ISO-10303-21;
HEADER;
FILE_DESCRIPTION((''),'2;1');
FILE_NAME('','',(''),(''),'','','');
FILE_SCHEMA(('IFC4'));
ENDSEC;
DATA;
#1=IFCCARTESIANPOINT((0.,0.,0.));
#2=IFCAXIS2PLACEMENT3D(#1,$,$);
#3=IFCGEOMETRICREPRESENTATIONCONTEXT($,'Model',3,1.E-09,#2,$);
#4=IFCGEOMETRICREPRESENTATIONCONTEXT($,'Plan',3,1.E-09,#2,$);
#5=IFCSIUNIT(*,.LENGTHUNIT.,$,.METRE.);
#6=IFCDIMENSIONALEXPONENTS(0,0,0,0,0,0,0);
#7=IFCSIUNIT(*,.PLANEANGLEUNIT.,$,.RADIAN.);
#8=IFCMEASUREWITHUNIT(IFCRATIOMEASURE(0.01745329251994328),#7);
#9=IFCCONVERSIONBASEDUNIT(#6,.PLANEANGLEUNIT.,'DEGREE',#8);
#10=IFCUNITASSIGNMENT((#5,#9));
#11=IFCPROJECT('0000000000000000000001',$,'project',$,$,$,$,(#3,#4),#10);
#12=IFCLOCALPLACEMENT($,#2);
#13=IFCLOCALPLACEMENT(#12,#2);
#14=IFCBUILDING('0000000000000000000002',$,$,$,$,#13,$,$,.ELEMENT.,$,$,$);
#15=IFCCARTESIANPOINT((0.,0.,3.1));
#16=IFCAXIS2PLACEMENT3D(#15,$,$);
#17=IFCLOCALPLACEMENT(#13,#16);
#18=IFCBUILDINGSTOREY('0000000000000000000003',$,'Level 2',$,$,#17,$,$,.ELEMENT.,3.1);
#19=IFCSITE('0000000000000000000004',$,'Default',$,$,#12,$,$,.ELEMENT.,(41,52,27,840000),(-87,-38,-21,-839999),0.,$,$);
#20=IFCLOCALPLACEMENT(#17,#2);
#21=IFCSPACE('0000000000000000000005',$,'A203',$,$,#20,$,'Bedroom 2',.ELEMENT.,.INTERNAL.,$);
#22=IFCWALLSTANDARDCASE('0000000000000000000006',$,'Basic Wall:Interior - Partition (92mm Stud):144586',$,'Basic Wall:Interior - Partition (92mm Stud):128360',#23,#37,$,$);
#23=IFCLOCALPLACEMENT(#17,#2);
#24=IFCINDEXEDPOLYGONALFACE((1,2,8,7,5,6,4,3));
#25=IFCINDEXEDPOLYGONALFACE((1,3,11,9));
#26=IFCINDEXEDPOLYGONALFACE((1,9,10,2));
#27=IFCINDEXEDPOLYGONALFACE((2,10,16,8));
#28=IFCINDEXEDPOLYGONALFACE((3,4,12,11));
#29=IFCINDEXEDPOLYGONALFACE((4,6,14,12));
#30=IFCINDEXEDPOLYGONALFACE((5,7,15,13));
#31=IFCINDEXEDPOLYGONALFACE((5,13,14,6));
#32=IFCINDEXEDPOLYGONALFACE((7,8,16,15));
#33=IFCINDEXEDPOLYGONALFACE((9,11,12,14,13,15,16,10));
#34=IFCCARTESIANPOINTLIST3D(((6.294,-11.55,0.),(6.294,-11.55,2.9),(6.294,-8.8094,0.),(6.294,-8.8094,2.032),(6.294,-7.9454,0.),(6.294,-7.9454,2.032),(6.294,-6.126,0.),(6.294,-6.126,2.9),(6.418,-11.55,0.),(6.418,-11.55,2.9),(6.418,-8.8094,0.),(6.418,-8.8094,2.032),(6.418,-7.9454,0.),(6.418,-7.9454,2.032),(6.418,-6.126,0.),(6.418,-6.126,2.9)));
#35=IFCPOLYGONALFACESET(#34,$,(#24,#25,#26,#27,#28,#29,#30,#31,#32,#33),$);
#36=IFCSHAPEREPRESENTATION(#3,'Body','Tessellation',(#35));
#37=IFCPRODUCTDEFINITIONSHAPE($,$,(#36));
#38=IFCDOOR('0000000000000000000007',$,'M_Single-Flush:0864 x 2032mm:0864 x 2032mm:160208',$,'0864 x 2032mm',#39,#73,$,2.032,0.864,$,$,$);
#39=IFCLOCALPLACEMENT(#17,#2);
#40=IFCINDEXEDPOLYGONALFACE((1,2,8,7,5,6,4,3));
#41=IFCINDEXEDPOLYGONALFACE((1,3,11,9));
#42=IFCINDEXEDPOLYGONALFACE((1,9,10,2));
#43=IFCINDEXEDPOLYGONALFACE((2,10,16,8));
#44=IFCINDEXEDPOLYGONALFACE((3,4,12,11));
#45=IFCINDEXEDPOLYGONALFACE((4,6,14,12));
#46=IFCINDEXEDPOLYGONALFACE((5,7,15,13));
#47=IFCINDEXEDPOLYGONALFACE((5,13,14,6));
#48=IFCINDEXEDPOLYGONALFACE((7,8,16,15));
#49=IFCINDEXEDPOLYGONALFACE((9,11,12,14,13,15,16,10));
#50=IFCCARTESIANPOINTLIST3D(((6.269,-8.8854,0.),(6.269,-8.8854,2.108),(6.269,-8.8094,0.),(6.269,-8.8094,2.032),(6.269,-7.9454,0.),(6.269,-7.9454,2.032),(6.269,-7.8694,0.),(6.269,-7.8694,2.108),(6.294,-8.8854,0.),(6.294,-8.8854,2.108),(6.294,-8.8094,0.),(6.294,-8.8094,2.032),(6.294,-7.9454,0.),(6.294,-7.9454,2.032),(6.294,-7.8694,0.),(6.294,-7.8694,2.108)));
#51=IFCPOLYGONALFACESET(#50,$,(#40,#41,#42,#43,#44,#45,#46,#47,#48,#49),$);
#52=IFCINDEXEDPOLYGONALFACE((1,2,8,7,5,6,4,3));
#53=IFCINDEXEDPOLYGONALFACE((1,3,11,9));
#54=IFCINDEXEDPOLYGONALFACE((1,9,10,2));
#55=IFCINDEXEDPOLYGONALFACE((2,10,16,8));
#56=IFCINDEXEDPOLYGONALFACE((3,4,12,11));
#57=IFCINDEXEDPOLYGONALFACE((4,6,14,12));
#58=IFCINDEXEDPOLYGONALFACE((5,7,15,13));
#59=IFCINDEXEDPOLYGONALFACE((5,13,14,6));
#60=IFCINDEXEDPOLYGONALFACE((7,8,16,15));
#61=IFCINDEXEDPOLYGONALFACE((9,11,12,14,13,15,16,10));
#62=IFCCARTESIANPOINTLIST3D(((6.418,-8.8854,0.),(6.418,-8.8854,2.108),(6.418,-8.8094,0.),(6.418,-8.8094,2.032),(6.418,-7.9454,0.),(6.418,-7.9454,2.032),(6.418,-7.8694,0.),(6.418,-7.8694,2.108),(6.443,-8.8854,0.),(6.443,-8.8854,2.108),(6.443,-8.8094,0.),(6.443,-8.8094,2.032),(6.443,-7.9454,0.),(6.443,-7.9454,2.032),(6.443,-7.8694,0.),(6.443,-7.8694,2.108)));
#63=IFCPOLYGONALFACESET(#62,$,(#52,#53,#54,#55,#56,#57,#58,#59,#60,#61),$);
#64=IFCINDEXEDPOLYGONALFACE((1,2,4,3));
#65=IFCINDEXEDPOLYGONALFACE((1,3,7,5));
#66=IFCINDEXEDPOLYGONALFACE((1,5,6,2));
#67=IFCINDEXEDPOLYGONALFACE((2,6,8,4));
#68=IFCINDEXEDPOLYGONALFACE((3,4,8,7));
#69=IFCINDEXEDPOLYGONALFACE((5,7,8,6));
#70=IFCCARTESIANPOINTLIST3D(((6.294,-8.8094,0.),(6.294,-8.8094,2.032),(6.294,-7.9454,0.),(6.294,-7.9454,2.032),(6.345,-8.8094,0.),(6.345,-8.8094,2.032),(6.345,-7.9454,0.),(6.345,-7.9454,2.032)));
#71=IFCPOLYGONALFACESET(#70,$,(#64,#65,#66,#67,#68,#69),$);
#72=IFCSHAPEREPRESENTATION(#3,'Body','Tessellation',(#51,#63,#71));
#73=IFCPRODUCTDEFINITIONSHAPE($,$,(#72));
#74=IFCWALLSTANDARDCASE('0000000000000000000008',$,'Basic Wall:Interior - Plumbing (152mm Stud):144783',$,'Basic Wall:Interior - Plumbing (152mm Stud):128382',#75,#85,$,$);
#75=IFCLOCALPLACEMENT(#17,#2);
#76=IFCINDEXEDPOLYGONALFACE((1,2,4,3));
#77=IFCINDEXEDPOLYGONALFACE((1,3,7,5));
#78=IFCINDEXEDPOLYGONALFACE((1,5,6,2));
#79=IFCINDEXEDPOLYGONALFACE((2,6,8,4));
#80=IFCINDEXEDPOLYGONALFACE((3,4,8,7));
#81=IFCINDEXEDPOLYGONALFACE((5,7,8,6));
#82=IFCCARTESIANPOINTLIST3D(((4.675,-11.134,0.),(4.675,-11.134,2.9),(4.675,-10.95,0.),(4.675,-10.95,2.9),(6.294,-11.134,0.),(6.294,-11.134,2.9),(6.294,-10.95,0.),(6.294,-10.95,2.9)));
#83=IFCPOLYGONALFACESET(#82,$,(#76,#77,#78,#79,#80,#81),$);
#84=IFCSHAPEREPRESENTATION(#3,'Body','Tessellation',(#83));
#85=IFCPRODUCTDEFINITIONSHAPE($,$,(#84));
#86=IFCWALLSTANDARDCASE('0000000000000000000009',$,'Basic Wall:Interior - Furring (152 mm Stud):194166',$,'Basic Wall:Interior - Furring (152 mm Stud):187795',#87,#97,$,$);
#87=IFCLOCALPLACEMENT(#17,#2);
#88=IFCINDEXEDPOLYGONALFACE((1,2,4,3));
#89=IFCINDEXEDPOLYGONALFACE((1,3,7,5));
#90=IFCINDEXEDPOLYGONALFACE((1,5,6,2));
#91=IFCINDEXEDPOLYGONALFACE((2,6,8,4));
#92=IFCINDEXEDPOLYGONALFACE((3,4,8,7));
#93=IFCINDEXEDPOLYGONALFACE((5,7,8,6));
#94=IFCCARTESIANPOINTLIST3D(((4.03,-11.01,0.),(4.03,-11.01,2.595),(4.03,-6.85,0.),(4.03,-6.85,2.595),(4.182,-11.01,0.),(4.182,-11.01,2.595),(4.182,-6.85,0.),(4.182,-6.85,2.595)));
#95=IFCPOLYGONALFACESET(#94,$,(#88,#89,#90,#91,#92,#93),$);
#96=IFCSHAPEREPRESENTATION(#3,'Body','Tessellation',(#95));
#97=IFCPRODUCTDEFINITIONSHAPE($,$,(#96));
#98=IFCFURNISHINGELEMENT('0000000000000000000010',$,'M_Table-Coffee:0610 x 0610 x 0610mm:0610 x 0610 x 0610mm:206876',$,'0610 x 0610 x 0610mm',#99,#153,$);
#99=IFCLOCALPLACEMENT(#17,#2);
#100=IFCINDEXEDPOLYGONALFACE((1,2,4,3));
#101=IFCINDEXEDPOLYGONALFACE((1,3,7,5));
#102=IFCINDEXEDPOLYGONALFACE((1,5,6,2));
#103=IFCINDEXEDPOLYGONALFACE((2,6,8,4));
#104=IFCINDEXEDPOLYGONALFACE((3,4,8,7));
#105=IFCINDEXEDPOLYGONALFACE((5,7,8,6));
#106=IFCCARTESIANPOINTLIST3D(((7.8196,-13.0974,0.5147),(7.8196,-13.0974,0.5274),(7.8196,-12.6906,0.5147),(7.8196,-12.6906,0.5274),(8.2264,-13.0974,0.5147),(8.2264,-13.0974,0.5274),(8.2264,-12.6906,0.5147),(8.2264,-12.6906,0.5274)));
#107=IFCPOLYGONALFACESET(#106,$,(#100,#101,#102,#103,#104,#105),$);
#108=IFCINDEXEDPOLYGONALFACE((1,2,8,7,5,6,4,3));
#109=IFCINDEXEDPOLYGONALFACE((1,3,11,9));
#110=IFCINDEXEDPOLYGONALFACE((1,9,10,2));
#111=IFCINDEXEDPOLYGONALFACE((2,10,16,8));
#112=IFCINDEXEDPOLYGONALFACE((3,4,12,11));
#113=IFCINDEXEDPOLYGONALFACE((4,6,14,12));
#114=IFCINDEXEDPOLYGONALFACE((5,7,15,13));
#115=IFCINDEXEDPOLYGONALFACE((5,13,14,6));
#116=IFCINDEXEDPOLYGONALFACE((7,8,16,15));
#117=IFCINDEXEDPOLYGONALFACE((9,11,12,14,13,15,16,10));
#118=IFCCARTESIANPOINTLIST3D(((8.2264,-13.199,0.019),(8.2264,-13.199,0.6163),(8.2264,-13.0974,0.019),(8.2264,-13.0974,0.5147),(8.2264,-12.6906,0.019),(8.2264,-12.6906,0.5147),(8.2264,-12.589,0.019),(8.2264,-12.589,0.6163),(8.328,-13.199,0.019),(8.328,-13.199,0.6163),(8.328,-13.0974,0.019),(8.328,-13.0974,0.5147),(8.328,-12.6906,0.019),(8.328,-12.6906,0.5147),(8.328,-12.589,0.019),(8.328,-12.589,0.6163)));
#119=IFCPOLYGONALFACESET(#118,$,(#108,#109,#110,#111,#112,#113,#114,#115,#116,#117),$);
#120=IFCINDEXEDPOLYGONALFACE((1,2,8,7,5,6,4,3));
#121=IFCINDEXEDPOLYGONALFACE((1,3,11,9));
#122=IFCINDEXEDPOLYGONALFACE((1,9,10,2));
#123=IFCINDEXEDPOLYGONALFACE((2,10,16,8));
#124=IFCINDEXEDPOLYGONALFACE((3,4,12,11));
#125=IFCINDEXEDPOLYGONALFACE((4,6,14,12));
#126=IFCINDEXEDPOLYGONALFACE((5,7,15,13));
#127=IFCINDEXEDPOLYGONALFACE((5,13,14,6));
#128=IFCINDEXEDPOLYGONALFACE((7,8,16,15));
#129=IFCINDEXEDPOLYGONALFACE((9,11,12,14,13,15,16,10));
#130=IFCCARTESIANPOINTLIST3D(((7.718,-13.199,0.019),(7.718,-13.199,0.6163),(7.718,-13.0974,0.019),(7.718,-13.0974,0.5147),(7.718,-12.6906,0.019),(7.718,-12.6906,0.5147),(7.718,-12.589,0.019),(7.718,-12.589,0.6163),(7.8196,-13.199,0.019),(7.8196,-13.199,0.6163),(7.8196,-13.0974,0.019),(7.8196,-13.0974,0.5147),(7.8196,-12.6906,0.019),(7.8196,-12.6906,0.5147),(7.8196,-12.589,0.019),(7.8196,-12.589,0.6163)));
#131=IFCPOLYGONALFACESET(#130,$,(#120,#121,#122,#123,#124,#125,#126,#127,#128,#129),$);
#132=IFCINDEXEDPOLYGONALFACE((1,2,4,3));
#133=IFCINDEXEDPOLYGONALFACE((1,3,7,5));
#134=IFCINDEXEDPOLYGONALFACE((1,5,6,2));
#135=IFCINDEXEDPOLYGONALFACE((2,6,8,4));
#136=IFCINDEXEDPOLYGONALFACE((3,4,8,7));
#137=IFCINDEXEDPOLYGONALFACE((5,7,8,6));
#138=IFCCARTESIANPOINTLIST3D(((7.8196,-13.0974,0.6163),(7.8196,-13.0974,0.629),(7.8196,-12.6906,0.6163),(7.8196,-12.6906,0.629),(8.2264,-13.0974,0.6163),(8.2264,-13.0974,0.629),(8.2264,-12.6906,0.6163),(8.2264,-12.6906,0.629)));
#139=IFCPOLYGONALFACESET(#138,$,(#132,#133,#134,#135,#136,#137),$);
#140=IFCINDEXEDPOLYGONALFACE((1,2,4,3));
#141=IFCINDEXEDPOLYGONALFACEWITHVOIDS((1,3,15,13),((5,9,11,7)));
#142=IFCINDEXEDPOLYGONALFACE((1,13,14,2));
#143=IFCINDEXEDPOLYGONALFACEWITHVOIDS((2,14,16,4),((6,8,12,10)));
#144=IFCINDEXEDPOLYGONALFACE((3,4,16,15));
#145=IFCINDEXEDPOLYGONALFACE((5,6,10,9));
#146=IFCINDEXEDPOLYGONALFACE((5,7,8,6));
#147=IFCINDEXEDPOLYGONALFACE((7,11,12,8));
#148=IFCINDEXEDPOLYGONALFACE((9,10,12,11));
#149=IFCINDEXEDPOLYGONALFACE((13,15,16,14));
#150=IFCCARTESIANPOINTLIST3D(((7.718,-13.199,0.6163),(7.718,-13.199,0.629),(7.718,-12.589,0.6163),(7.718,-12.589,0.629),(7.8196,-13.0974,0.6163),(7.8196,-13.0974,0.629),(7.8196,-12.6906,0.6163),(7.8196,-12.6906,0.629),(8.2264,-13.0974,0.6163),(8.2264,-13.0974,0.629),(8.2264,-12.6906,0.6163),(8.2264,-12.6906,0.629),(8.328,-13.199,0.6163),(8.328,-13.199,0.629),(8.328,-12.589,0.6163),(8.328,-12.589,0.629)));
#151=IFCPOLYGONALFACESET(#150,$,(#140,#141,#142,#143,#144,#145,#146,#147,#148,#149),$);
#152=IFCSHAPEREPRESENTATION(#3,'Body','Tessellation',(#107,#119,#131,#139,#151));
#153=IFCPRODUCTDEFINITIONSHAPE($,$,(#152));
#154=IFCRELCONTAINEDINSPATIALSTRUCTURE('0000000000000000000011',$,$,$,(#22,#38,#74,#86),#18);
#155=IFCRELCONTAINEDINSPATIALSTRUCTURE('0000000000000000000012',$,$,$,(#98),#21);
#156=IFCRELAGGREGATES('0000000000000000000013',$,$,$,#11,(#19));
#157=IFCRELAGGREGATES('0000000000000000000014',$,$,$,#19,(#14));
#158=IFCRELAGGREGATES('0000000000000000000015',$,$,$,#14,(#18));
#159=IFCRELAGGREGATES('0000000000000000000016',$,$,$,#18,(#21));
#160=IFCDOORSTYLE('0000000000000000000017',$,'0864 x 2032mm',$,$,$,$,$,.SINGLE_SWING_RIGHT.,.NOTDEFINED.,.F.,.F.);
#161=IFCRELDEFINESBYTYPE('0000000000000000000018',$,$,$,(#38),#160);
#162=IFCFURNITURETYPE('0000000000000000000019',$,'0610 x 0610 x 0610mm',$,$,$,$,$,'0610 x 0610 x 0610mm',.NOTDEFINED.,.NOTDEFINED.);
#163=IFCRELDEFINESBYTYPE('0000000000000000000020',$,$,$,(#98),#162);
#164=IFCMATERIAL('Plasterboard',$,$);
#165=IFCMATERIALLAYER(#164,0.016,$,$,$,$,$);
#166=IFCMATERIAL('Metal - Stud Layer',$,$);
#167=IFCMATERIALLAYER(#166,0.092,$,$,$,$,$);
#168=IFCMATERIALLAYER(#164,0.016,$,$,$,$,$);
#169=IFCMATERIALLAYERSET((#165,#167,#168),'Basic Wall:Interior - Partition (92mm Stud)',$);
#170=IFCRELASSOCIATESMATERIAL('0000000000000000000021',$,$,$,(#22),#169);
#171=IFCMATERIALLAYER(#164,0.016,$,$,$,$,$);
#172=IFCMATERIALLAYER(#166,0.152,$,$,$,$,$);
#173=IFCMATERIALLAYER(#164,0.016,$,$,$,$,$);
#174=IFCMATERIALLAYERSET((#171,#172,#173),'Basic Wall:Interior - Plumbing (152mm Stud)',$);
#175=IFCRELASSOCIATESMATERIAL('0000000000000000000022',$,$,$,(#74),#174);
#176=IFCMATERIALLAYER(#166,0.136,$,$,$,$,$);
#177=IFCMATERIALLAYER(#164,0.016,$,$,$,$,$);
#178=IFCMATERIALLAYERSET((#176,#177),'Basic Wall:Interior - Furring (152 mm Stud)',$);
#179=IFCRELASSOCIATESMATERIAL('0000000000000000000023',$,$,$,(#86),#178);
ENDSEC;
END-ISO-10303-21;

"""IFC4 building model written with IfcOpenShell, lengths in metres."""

from ifc_helpers import new_model, entity, si_unit, converted_unit, frame, frame_2d, origin, origin_2d_with_axis, place, context, project, spatial, polyline, rectangle, outline, extrude, source, transform, mapped, material, layer, layer_set, layer_usage, type_object, type_shapes, element, fill, save


model = new_model("IFC4")

# Units and contexts
model_context = context("Model", 3, precision=1e-09, world=origin())
plan_context = context("Plan", 3, precision=1e-09, world=origin())
ifc_project = project(units=[si_unit("LENGTHUNIT", "METRE"), converted_unit("PLANEANGLEUNIT", "DEGREE", entity("IfcRatioMeasure", 0.01745329251994328), si_unit("PLANEANGLEUNIT", "RADIAN"), dimensions=[0, 0, 0, 0, 0, 0, 0])], contexts=[model_context, plan_context])

# Site, building, storey
site_placement = place(None, origin())
site = spatial("IfcSite", under=ifc_project, at=site_placement, Name="Default", CompositionType="ELEMENT", RefLatitude=(41, 52, 27, 840000), RefLongitude=(-87, -38, -21, -839999), RefElevation=0.0)
building_placement = place(site_placement, origin())
building = spatial("IfcBuilding", under=site, at=building_placement, CompositionType="ELEMENT")
storey_placement = place(building_placement, frame((0.0, 0.0, 3.1)))
storey = spatial("IfcBuildingStorey", under=building, at=storey_placement, Name="Level 2", CompositionType="ELEMENT", Elevation=3.1)

# Shared definitions
ifc_material_1 = material(Name="Metal - Stud Layer")
ifc_material_2 = material(Name="Plasterboard")

# Shared definitions
ifc_layer_1 = layer(ifc_material_2, 0.016)
ifc_layer_2 = layer(ifc_material_1, 0.092)
ifc_layer_3 = layer(ifc_material_2, 0.016)
ifc_layer_set_1 = layer_set([ifc_layer_1, ifc_layer_2, ifc_layer_3], Name="Basic Wall:Interior - Partition (92mm Stud)")

# Wall, opening, door
ifc_layer_usage_1 = layer_usage(ifc_layer_set_1, "AXIS2", "NEGATIVE", 0.062)
wall_1_placement = place(storey_placement, frame((6.356, -11.55, 0.0), z_axis=(0.0, 0.0, 1.0), x_axis=(0.0, 1.0, 0.0)))
wall_1 = element("IfcWallStandardCase", 1, at=wall_1_placement, inside=storey, material=ifc_layer_usage_1, Name="Basic Wall:Interior - Partition (92mm Stud):144586", ObjectType="Basic Wall:Interior - Partition (92mm Stud):128360", context=model_context, shape_type="SweptSolid", body=[
    extrude(rectangle(XDim=5.424, YDim=0.124, at=frame_2d((2.712, 0.0), x_axis=(-1.0, 0.0))), origin(), (0.0, 0.0, 1.0), 2.9),
])
opening_1_placement = place(wall_1_placement, frame((2.7406, -0.062, 0.0)))
opening_1 = element("IfcOpeningElement", 2, at=opening_1_placement, cuts=wall_1, ObjectType="Opening", context=model_context, shape_type="SweptSolid", body=[
    extrude(rectangle(XDim=0.864, YDim=2.032, at=frame_2d((1.016, 0.432), x_axis=(0.0, 1.0))), frame((0.0, 0.0, 0.0), z_axis=(0.0, 1.0, 0.0), x_axis=(0.0, 0.0, 1.0)), (0.0, 0.0, 1.0), 0.124),
])
door_style = type_object("IfcDoorStyle", Name="0864 x 2032mm", ConstructionType="NOTDEFINED", OperationType="SINGLE_SWING_RIGHT", ParameterTakesPrecedence=False, Sizeable=False)
shared_shape_1 = source(origin(), model_context, "Body", "SweptSolid", [
    extrude(outline(polyline([(-0.508, -1.073), (0.508, -1.073), (0.508, 1.035), (0.432, 1.035), (0.432, -0.997), (-0.432, -0.997), (-0.432, 1.035), (-0.508, 1.035), (-0.508, -1.073)])), frame((0.432, 0.124, 1.035), z_axis=(0.0, 1.0, 0.0), x_axis=(1.0, 0.0, 0.0)), (0.0, 0.0, 1.0), 0.025),
    extrude(outline(polyline([(-1.073, -0.508), (1.035, -0.508), (1.035, -0.432), (-0.997, -0.432), (-0.997, 0.432), (1.035, 0.432), (1.035, 0.508), (-1.073, 0.508), (-1.073, -0.508)])), frame((0.432, -0.025, 1.035), z_axis=(0.0, 1.0, 0.0), x_axis=(0.0, 0.0, -1.0)), (0.0, 0.0, 1.0), 0.025),
    extrude(rectangle(XDim=0.051, YDim=0.864, at=origin_2d_with_axis()), frame((0.432, 0.0985, 0.0), z_axis=(0.0, 0.0, 1.0), x_axis=(0.0, 1.0, 0.0)), (0.0, 0.0, 1.0), 2.032),
])
type_shapes(door_style, [shared_shape_1])
door_placement = place(opening_1_placement, origin())
door = element("IfcDoor", 3, at=door_placement, inside=storey, type_object=door_style, Name="M_Single-Flush:0864 x 2032mm:0864 x 2032mm:160208", ObjectType="0864 x 2032mm", OverallHeight=2.032, OverallWidth=0.864, context=model_context, shape_type="MappedRepresentation", body=[
    mapped(shared_shape_1, transform((0.0, 0.0, 0.0), scale=1.0)),
])
fill(opening_1, door)

# Walls
ifc_layer_4 = layer(ifc_material_2, 0.016)
ifc_layer_5 = layer(ifc_material_1, 0.152)
ifc_layer_6 = layer(ifc_material_2, 0.016)
ifc_layer_set_2 = layer_set([ifc_layer_4, ifc_layer_5, ifc_layer_6], Name="Basic Wall:Interior - Plumbing (152mm Stud)")
ifc_layer_usage_2 = layer_usage(ifc_layer_set_2, "AXIS2", "NEGATIVE", 0.092)
wall_2_placement = place(storey_placement, frame((6.294, -11.042, 0.0), z_axis=(0.0, 0.0, 1.0), x_axis=(-1.0, 0.0, 0.0)))
element("IfcWallStandardCase", 4, at=wall_2_placement, inside=storey, material=ifc_layer_usage_2, Name="Basic Wall:Interior - Plumbing (152mm Stud):144783", ObjectType="Basic Wall:Interior - Plumbing (152mm Stud):128382", context=model_context, shape_type="SweptSolid", body=[
    extrude(rectangle(XDim=1.619, YDim=0.184, at=frame_2d((0.8095, 0.0), x_axis=(-1.0, 0.0))), origin(), (0.0, 0.0, 1.0), 2.9),
])
ifc_layer_7 = layer(ifc_material_1, 0.136)
ifc_layer_8 = layer(ifc_material_2, 0.016)
ifc_layer_set_3 = layer_set([ifc_layer_7, ifc_layer_8], Name="Basic Wall:Interior - Furring (152 mm Stud)")
ifc_layer_usage_3 = layer_usage(ifc_layer_set_3, "AXIS2", "POSITIVE", -0.076)
wall_3_placement = place(storey_placement, frame((4.106, -11.01, 0.0), z_axis=(0.0, 0.0, 1.0), x_axis=(0.0, 1.0, 0.0)))
element("IfcWallStandardCase", 5, at=wall_3_placement, inside=storey, material=ifc_layer_usage_3, Name="Basic Wall:Interior - Furring (152 mm Stud):194166", ObjectType="Basic Wall:Interior - Furring (152 mm Stud):187795", context=model_context, shape_type="SweptSolid", body=[
    extrude(rectangle(XDim=4.16, YDim=0.152, at=frame_2d((2.08, 0.0), x_axis=(-1.0, 0.0))), origin(), (0.0, 0.0, 1.0), 2.595),
])

# Shared definitions
space_placement = place(storey_placement, origin())
space = spatial("IfcSpace", under=storey, at=space_placement, Name="A203", LongName="Bedroom 2", CompositionType="ELEMENT", PredefinedType="INTERNAL")

# Furnishing element
furniture_type = type_object("IfcFurnitureType", Name="0610 x 0610 x 0610mm", ElementType="0610 x 0610 x 0610mm", AssemblyPlace="NOTDEFINED")
shared_shape_2 = source(origin(), model_context, "Body", "SweptSolid", [
    extrude(rectangle(XDim=0.4068, YDim=0.4068, at=origin_2d_with_axis()), frame((0.0183, 0.0952, 0.4957), z_axis=(0.0, 0.0, 1.0), x_axis=(-1.0, 0.0, 0.0)), (0.0, 0.0, 1.0), 0.0127),
    extrude(outline(polyline([(-0.2732, -0.305), (0.324, -0.305), (0.324, 0.305), (-0.2732, 0.305), (-0.2732, 0.2034), (0.2225, 0.2034), (0.2225, -0.2034), (-0.2732, -0.2034), (-0.2732, -0.305)])), frame((0.2217, 0.0952, 0.2732), z_axis=(1.0, 0.0, 0.0), x_axis=(0.0, 0.0, 1.0)), (0.0, 0.0, 1.0), 0.1016),
    extrude(outline(polyline([(-0.305, -0.3241), (0.305, -0.3241), (0.305, 0.2733), (0.2034, 0.2733), (0.2034, -0.2224), (-0.2034, -0.2224), (-0.2034, 0.2733), (-0.305, 0.2733), (-0.305, -0.3241)])), frame((-0.2867, 0.0952, 0.2733), z_axis=(1.0, 0.0, 0.0), x_axis=(0.0, -1.0, 0.0)), (0.0, 0.0, 1.0), 0.1016),
    extrude(rectangle(XDim=0.4068, YDim=0.4068, at=origin_2d_with_axis()), frame((0.0183, 0.0952, 0.5973), z_axis=(0.0, 0.0, 1.0), x_axis=(-1.0, 0.0, 0.0)), (0.0, 0.0, 1.0), 0.0127),
    extrude(outline(polyline([(-0.305, -0.305), (0.305, -0.305), (0.305, 0.305), (-0.305, 0.305), (-0.305, -0.305)]), holes=[polyline([(-0.2034, -0.2034), (-0.2034, 0.2034), (0.2034, 0.2034), (0.2034, -0.2034), (-0.2034, -0.2034)])]), frame((0.0183, 0.0952, 0.5973), z_axis=(0.0, 0.0, 1.0), x_axis=(-1.0, 0.0, 0.0)), (0.0, 0.0, 1.0), 0.0127),
])
type_shapes(furniture_type, [shared_shape_2])
furnishing_placement = place(space_placement, frame((8.0047, -12.9892, 0.019)))
element("IfcFurnishingElement", 6, at=furnishing_placement, inside=space, type_object=furniture_type, Name="M_Table-Coffee:0610 x 0610 x 0610mm:0610 x 0610 x 0610mm:206876", ObjectType="0610 x 0610 x 0610mm", context=model_context, shape_type="MappedRepresentation", body=[
    mapped(shared_shape_2, transform((0.0, 0.0, 0.0), scale=1.0)),
])

save(model, "model.ifc")
